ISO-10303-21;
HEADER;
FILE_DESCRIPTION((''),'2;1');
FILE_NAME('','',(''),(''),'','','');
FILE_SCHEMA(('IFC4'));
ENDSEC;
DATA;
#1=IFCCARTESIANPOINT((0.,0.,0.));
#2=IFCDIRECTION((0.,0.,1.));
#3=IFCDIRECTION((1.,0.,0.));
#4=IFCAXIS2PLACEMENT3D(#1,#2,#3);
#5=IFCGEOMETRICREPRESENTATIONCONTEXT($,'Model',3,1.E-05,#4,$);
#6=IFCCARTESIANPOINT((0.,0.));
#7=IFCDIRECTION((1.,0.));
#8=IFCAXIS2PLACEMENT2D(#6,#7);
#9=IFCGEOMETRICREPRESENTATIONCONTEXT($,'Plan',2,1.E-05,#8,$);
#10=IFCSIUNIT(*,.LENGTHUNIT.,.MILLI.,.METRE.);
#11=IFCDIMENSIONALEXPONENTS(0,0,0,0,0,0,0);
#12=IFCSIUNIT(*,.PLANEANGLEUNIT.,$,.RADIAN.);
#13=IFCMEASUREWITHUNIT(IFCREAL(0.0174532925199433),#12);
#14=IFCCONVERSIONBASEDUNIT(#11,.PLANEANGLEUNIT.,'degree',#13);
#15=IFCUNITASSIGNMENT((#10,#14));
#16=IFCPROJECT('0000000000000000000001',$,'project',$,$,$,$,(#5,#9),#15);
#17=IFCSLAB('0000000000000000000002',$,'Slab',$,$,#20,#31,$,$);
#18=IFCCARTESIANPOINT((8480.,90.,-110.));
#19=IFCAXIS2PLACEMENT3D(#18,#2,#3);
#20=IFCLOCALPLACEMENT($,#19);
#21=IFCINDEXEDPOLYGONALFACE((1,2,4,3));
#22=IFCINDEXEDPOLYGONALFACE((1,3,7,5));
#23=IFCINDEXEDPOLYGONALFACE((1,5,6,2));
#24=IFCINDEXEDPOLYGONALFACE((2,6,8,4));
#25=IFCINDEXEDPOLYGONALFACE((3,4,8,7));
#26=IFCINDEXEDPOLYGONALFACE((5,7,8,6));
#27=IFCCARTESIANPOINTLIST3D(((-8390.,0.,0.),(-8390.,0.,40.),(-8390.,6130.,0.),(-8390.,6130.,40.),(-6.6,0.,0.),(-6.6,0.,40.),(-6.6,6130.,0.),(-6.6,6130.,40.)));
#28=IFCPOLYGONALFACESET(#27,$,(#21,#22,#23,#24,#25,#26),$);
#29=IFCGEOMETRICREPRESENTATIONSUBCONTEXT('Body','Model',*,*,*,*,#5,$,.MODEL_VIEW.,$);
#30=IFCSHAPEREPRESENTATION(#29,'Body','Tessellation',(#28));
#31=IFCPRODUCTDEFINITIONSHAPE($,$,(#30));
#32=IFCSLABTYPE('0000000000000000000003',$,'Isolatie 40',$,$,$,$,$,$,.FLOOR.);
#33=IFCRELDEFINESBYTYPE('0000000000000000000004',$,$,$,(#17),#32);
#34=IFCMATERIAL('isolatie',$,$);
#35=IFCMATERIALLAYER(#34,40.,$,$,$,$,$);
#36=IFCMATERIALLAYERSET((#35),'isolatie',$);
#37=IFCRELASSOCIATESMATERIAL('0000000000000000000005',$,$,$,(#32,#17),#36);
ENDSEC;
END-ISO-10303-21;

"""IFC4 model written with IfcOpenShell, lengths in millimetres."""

from ifc_helpers import new_model, entity, si_unit, converted_unit, frame, origin_with_axes, origin_2d_with_axis, place, context, subcontext, project, line, indexed_curve, outline, extrude, material, layer, layer_set, layer_usage, type_object, element, save


model = new_model("IFC4")

# Units and contexts
model_context = context("Model", 3, precision=1e-05, world=origin_with_axes())
plan_context = context("Plan", 2, precision=1e-05, world=origin_2d_with_axis())
body_context = subcontext(model_context, "Body", "Model", "MODEL_VIEW")
ifc_project = project(units=[si_unit("LENGTHUNIT", "METRE", prefix="MILLI"), converted_unit("PLANEANGLEUNIT", "degree", entity("IfcReal", 0.0174532925199433), si_unit("PLANEANGLEUNIT", "RADIAN"), dimensions=[0, 0, 0, 0, 0, 0, 0])], contexts=[model_context, plan_context])

# Slab
ifc_material = material(Name="isolatie")
ifc_layer = layer(ifc_material, 40.0)
ifc_layer_set = layer_set([ifc_layer], Name="isolatie")
ifc_layer_usage = layer_usage(ifc_layer_set, "AXIS3", "POSITIVE", 0.0)
slab_type = type_object("IfcSlabType", Name="Isolatie 40", PredefinedType="FLOOR", material=ifc_layer_set)
slab_placement = place(None, frame((8480.0, 90.0, -110.0), z_axis=(0.0, 0.0, 1.0), x_axis=(1.0, 0.0, 0.0)))
element("IfcSlab", 1, at=slab_placement, type_object=slab_type, material=ifc_layer_usage, Name="Slab", context=body_context, shape_type="SweptSolid", body=[
    extrude(outline(indexed_curve([(-8390.0, 0.0), (-6.6, 0.0), (-6.6, 6130.0), (-8390.0, 6130.0)], segments=[line(4, 1), line(1, 2), line(2, 3), line(3, 4)], self_intersect=False)), None, (0.0, 0.0, 1.0), 40.0),
])

save(model, "model.ifc")
